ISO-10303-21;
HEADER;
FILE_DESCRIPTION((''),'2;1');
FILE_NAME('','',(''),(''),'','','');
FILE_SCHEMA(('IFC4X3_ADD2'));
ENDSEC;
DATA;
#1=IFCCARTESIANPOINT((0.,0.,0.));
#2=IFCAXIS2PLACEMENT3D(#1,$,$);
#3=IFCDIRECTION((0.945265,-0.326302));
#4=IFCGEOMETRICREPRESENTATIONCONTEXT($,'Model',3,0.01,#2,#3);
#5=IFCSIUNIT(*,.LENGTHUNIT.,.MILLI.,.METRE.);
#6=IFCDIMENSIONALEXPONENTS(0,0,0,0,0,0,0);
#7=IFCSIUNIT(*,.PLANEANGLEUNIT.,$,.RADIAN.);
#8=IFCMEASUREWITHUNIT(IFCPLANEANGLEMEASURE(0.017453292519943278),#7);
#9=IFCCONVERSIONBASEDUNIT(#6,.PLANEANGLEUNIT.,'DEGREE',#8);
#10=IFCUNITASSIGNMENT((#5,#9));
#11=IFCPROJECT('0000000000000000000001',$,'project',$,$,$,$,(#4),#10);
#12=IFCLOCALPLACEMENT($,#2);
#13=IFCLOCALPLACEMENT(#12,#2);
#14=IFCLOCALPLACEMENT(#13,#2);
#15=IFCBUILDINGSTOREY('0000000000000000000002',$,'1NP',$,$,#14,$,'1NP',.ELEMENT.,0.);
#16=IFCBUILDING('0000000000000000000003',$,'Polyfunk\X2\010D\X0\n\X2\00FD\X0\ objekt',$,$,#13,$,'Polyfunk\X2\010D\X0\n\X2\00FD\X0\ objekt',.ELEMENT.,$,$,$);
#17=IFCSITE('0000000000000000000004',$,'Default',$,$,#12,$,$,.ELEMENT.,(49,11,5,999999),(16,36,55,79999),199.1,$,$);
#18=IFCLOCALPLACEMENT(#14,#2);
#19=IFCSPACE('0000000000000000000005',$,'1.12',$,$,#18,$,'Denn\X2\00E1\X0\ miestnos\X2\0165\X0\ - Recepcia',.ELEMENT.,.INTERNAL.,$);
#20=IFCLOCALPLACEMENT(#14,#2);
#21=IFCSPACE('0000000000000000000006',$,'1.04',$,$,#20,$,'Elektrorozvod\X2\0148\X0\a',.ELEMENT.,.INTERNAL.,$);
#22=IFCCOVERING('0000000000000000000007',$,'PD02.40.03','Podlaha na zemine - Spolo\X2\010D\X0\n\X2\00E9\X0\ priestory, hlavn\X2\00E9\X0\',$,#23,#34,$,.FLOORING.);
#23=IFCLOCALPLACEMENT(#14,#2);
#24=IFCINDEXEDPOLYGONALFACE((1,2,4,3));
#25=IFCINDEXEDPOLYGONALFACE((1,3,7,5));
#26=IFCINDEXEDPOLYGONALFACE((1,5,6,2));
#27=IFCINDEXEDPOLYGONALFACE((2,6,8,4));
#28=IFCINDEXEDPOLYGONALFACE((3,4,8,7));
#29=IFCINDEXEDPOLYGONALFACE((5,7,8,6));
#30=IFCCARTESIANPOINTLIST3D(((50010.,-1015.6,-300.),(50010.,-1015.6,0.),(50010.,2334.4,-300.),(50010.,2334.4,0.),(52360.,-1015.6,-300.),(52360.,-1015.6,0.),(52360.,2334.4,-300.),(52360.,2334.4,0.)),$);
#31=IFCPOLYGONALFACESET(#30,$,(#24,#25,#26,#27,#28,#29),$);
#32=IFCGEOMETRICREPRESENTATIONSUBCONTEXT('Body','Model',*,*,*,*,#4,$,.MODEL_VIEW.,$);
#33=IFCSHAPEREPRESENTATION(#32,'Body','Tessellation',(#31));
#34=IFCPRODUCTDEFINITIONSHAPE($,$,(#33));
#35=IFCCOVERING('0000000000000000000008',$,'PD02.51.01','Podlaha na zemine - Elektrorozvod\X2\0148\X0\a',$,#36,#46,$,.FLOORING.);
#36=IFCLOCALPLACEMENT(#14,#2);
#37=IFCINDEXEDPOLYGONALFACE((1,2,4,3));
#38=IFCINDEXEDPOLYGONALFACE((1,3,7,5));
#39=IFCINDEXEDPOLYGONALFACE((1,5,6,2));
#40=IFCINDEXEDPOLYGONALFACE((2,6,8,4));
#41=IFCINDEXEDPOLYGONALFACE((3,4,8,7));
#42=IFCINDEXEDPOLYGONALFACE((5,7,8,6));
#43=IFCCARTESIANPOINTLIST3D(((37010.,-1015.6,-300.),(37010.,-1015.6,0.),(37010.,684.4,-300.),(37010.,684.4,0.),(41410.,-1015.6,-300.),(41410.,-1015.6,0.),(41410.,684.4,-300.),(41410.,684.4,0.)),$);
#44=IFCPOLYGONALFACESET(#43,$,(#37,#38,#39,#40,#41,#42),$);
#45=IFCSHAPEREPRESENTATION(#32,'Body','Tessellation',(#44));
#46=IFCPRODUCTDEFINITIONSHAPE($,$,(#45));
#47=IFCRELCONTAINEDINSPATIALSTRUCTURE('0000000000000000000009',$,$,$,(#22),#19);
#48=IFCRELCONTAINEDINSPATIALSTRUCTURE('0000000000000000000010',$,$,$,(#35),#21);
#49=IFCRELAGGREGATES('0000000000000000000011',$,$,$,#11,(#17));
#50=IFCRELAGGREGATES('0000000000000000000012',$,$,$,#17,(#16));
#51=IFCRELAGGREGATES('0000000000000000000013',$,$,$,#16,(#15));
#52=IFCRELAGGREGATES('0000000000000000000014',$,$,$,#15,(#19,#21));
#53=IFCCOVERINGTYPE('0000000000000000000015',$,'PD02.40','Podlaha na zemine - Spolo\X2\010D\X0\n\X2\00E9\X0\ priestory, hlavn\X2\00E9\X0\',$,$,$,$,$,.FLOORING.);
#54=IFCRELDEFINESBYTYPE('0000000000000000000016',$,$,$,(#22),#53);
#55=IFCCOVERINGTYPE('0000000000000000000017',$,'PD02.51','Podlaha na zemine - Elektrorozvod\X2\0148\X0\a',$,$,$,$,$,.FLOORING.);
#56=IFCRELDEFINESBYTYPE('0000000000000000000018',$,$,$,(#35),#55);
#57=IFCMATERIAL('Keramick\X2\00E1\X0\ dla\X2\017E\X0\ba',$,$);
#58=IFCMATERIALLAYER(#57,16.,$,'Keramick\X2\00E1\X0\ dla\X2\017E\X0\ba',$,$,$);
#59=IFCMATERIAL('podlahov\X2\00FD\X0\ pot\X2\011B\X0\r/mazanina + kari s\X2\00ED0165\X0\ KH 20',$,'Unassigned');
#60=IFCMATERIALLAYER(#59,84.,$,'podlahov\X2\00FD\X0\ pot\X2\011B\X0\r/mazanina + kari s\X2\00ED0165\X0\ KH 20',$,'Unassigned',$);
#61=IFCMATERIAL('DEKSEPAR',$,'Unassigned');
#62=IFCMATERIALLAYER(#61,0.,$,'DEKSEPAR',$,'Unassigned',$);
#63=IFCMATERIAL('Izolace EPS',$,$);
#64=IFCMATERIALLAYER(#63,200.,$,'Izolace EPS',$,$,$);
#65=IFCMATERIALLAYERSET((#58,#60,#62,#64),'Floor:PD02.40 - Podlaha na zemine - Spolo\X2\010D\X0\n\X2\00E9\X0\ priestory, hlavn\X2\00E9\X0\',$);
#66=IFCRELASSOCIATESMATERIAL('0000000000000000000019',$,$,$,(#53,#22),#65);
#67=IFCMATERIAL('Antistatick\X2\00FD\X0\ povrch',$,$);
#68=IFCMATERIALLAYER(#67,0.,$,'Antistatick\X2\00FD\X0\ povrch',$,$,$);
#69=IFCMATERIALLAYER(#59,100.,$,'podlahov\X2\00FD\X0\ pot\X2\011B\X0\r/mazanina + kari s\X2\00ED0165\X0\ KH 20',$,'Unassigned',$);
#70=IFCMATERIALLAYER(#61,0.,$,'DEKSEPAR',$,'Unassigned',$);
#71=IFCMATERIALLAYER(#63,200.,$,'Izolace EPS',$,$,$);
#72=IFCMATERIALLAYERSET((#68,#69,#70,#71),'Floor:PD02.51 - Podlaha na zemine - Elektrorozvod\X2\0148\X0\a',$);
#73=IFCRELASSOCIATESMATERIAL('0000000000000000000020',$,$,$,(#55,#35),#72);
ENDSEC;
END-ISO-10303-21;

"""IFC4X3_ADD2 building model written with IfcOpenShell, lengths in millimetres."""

from ifc_helpers import new_model, entity, si_unit, converted_unit, direction, frame, frame_2d, origin, place, context, subcontext, project, spatial, rectangle, extrude, material, layer, layer_set, layer_usage, type_object, element, save


model = new_model("IFC4X3_ADD2")

# Units and contexts
model_context = context("Model", 3, precision=0.01, world=origin(), true_north=direction((0.945265, -0.326302)))
body_context = subcontext(model_context, "Body", "Model", "MODEL_VIEW")
ifc_project = project(units=[si_unit("LENGTHUNIT", "METRE", prefix="MILLI"), converted_unit("PLANEANGLEUNIT", "DEGREE", entity("IfcPlaneAngleMeasure", 0.017453292519943278), si_unit("PLANEANGLEUNIT", "RADIAN"), dimensions=[0, 0, 0, 0, 0, 0, 0])], contexts=[model_context])

# Site, building, storey
site_placement = place(None, origin())
site = spatial("IfcSite", under=ifc_project, at=site_placement, Name="Default", CompositionType="ELEMENT", RefLatitude=(49, 11, 5, 999999), RefLongitude=(16, 36, 55, 79999), RefElevation=199.1)
building_placement = place(site_placement, origin())
building = spatial("IfcBuilding", under=site, at=building_placement, Name="Polyfunkčný objekt", LongName="Polyfunkčný objekt", CompositionType="ELEMENT")
storey_placement = place(building_placement, origin())
storey = spatial("IfcBuildingStorey", under=building, at=storey_placement, Name="1NP", LongName="1NP", CompositionType="ELEMENT", Elevation=0.0)

# Shared definitions
ifc_material_1 = material(Name="podlahový potěr/mazanina + kari síť KH 20", Category="Unassigned")
ifc_material_2 = material(Name="DEKSEPAR", Category="Unassigned")
ifc_material_3 = material(Name="Izolace EPS")

# Shared definitions
ifc_material_4 = material(Name="Keramická dlažba")

# Shared definitions
ifc_layer_1 = layer(ifc_material_4, 16.0, Name="Keramická dlažba")
ifc_layer_2 = layer(ifc_material_1, 84.0, Name="podlahový potěr/mazanina + kari síť KH 20", Category="Unassigned")
ifc_layer_3 = layer(ifc_material_2, 0.0, Name="DEKSEPAR", Category="Unassigned")
ifc_layer_4 = layer(ifc_material_3, 200.0, Name="Izolace EPS")
ifc_layer_set_1 = layer_set([ifc_layer_1, ifc_layer_2, ifc_layer_3, ifc_layer_4], Name="Floor:PD02.40 - Podlaha na zemine - Spoločné priestory, hlavné")
covering_type_1 = type_object("IfcCoveringType", Name="PD02.40", Description="Podlaha na zemine - Spoločné priestory, hlavné", PredefinedType="FLOORING", material=ifc_layer_set_1)

# Shared definitions
space_1_placement = place(storey_placement, origin())
space_1 = spatial("IfcSpace", under=storey, at=space_1_placement, Name="1.12", LongName="Denná miestnosť - Recepcia", CompositionType="ELEMENT", PredefinedType="INTERNAL")

# Covering
ifc_layer_usage_1 = layer_usage(ifc_layer_set_1, "AXIS3", "POSITIVE", 0.0)
covering_1_placement = place(storey_placement, origin())
element("IfcCovering", 1, at=covering_1_placement, inside=space_1, type_object=covering_type_1, material=ifc_layer_usage_1, Name="PD02.40.03", Description="Podlaha na zemine - Spoločné priestory, hlavné", PredefinedType="FLOORING", context=body_context, shape_type="SweptSolid", body=[
    extrude(rectangle(XDim=3350.0, YDim=2350.0, at=frame_2d((0.0, 0.0), x_axis=(1.0, 0.0))), frame((51185.0, 659.4, 0.0), z_axis=(0.0, 0.0, -1.0), x_axis=(0.0, 1.0, 0.0)), (0.0, 0.0, 1.0), 300.0),
])

# Shared definitions
space_2_placement = place(storey_placement, origin())
space_2 = spatial("IfcSpace", under=storey, at=space_2_placement, Name="1.04", LongName="Elektrorozvodňa", CompositionType="ELEMENT", PredefinedType="INTERNAL")

# Covering
ifc_material_5 = material(Name="Antistatický povrch")
ifc_layer_5 = layer(ifc_material_5, 0.0, Name="Antistatický povrch")
ifc_layer_6 = layer(ifc_material_1, 100.0, Name="podlahový potěr/mazanina + kari síť KH 20", Category="Unassigned")
ifc_layer_7 = layer(ifc_material_2, 0.0, Name="DEKSEPAR", Category="Unassigned")
ifc_layer_8 = layer(ifc_material_3, 200.0, Name="Izolace EPS")
ifc_layer_set_2 = layer_set([ifc_layer_5, ifc_layer_6, ifc_layer_7, ifc_layer_8], Name="Floor:PD02.51 - Podlaha na zemine - Elektrorozvodňa")
ifc_layer_usage_2 = layer_usage(ifc_layer_set_2, "AXIS3", "POSITIVE", 0.0)
covering_type_2 = type_object("IfcCoveringType", Name="PD02.51", Description="Podlaha na zemine - Elektrorozvodňa", PredefinedType="FLOORING", material=ifc_layer_set_2)
covering_2_placement = place(storey_placement, origin())
element("IfcCovering", 2, at=covering_2_placement, inside=space_2, type_object=covering_type_2, material=ifc_layer_usage_2, Name="PD02.51.01", Description="Podlaha na zemine - Elektrorozvodňa", PredefinedType="FLOORING", context=body_context, shape_type="SweptSolid", body=[
    extrude(rectangle(XDim=1700.0, YDim=4400.0, at=frame_2d((0.0, 0.0), x_axis=(1.0, 0.0))), frame((39210.0, -165.6, 0.0), z_axis=(0.0, 0.0, -1.0), x_axis=(0.0, 1.0, 0.0)), (0.0, 0.0, 1.0), 300.0),
])

save(model, "model.ifc")
